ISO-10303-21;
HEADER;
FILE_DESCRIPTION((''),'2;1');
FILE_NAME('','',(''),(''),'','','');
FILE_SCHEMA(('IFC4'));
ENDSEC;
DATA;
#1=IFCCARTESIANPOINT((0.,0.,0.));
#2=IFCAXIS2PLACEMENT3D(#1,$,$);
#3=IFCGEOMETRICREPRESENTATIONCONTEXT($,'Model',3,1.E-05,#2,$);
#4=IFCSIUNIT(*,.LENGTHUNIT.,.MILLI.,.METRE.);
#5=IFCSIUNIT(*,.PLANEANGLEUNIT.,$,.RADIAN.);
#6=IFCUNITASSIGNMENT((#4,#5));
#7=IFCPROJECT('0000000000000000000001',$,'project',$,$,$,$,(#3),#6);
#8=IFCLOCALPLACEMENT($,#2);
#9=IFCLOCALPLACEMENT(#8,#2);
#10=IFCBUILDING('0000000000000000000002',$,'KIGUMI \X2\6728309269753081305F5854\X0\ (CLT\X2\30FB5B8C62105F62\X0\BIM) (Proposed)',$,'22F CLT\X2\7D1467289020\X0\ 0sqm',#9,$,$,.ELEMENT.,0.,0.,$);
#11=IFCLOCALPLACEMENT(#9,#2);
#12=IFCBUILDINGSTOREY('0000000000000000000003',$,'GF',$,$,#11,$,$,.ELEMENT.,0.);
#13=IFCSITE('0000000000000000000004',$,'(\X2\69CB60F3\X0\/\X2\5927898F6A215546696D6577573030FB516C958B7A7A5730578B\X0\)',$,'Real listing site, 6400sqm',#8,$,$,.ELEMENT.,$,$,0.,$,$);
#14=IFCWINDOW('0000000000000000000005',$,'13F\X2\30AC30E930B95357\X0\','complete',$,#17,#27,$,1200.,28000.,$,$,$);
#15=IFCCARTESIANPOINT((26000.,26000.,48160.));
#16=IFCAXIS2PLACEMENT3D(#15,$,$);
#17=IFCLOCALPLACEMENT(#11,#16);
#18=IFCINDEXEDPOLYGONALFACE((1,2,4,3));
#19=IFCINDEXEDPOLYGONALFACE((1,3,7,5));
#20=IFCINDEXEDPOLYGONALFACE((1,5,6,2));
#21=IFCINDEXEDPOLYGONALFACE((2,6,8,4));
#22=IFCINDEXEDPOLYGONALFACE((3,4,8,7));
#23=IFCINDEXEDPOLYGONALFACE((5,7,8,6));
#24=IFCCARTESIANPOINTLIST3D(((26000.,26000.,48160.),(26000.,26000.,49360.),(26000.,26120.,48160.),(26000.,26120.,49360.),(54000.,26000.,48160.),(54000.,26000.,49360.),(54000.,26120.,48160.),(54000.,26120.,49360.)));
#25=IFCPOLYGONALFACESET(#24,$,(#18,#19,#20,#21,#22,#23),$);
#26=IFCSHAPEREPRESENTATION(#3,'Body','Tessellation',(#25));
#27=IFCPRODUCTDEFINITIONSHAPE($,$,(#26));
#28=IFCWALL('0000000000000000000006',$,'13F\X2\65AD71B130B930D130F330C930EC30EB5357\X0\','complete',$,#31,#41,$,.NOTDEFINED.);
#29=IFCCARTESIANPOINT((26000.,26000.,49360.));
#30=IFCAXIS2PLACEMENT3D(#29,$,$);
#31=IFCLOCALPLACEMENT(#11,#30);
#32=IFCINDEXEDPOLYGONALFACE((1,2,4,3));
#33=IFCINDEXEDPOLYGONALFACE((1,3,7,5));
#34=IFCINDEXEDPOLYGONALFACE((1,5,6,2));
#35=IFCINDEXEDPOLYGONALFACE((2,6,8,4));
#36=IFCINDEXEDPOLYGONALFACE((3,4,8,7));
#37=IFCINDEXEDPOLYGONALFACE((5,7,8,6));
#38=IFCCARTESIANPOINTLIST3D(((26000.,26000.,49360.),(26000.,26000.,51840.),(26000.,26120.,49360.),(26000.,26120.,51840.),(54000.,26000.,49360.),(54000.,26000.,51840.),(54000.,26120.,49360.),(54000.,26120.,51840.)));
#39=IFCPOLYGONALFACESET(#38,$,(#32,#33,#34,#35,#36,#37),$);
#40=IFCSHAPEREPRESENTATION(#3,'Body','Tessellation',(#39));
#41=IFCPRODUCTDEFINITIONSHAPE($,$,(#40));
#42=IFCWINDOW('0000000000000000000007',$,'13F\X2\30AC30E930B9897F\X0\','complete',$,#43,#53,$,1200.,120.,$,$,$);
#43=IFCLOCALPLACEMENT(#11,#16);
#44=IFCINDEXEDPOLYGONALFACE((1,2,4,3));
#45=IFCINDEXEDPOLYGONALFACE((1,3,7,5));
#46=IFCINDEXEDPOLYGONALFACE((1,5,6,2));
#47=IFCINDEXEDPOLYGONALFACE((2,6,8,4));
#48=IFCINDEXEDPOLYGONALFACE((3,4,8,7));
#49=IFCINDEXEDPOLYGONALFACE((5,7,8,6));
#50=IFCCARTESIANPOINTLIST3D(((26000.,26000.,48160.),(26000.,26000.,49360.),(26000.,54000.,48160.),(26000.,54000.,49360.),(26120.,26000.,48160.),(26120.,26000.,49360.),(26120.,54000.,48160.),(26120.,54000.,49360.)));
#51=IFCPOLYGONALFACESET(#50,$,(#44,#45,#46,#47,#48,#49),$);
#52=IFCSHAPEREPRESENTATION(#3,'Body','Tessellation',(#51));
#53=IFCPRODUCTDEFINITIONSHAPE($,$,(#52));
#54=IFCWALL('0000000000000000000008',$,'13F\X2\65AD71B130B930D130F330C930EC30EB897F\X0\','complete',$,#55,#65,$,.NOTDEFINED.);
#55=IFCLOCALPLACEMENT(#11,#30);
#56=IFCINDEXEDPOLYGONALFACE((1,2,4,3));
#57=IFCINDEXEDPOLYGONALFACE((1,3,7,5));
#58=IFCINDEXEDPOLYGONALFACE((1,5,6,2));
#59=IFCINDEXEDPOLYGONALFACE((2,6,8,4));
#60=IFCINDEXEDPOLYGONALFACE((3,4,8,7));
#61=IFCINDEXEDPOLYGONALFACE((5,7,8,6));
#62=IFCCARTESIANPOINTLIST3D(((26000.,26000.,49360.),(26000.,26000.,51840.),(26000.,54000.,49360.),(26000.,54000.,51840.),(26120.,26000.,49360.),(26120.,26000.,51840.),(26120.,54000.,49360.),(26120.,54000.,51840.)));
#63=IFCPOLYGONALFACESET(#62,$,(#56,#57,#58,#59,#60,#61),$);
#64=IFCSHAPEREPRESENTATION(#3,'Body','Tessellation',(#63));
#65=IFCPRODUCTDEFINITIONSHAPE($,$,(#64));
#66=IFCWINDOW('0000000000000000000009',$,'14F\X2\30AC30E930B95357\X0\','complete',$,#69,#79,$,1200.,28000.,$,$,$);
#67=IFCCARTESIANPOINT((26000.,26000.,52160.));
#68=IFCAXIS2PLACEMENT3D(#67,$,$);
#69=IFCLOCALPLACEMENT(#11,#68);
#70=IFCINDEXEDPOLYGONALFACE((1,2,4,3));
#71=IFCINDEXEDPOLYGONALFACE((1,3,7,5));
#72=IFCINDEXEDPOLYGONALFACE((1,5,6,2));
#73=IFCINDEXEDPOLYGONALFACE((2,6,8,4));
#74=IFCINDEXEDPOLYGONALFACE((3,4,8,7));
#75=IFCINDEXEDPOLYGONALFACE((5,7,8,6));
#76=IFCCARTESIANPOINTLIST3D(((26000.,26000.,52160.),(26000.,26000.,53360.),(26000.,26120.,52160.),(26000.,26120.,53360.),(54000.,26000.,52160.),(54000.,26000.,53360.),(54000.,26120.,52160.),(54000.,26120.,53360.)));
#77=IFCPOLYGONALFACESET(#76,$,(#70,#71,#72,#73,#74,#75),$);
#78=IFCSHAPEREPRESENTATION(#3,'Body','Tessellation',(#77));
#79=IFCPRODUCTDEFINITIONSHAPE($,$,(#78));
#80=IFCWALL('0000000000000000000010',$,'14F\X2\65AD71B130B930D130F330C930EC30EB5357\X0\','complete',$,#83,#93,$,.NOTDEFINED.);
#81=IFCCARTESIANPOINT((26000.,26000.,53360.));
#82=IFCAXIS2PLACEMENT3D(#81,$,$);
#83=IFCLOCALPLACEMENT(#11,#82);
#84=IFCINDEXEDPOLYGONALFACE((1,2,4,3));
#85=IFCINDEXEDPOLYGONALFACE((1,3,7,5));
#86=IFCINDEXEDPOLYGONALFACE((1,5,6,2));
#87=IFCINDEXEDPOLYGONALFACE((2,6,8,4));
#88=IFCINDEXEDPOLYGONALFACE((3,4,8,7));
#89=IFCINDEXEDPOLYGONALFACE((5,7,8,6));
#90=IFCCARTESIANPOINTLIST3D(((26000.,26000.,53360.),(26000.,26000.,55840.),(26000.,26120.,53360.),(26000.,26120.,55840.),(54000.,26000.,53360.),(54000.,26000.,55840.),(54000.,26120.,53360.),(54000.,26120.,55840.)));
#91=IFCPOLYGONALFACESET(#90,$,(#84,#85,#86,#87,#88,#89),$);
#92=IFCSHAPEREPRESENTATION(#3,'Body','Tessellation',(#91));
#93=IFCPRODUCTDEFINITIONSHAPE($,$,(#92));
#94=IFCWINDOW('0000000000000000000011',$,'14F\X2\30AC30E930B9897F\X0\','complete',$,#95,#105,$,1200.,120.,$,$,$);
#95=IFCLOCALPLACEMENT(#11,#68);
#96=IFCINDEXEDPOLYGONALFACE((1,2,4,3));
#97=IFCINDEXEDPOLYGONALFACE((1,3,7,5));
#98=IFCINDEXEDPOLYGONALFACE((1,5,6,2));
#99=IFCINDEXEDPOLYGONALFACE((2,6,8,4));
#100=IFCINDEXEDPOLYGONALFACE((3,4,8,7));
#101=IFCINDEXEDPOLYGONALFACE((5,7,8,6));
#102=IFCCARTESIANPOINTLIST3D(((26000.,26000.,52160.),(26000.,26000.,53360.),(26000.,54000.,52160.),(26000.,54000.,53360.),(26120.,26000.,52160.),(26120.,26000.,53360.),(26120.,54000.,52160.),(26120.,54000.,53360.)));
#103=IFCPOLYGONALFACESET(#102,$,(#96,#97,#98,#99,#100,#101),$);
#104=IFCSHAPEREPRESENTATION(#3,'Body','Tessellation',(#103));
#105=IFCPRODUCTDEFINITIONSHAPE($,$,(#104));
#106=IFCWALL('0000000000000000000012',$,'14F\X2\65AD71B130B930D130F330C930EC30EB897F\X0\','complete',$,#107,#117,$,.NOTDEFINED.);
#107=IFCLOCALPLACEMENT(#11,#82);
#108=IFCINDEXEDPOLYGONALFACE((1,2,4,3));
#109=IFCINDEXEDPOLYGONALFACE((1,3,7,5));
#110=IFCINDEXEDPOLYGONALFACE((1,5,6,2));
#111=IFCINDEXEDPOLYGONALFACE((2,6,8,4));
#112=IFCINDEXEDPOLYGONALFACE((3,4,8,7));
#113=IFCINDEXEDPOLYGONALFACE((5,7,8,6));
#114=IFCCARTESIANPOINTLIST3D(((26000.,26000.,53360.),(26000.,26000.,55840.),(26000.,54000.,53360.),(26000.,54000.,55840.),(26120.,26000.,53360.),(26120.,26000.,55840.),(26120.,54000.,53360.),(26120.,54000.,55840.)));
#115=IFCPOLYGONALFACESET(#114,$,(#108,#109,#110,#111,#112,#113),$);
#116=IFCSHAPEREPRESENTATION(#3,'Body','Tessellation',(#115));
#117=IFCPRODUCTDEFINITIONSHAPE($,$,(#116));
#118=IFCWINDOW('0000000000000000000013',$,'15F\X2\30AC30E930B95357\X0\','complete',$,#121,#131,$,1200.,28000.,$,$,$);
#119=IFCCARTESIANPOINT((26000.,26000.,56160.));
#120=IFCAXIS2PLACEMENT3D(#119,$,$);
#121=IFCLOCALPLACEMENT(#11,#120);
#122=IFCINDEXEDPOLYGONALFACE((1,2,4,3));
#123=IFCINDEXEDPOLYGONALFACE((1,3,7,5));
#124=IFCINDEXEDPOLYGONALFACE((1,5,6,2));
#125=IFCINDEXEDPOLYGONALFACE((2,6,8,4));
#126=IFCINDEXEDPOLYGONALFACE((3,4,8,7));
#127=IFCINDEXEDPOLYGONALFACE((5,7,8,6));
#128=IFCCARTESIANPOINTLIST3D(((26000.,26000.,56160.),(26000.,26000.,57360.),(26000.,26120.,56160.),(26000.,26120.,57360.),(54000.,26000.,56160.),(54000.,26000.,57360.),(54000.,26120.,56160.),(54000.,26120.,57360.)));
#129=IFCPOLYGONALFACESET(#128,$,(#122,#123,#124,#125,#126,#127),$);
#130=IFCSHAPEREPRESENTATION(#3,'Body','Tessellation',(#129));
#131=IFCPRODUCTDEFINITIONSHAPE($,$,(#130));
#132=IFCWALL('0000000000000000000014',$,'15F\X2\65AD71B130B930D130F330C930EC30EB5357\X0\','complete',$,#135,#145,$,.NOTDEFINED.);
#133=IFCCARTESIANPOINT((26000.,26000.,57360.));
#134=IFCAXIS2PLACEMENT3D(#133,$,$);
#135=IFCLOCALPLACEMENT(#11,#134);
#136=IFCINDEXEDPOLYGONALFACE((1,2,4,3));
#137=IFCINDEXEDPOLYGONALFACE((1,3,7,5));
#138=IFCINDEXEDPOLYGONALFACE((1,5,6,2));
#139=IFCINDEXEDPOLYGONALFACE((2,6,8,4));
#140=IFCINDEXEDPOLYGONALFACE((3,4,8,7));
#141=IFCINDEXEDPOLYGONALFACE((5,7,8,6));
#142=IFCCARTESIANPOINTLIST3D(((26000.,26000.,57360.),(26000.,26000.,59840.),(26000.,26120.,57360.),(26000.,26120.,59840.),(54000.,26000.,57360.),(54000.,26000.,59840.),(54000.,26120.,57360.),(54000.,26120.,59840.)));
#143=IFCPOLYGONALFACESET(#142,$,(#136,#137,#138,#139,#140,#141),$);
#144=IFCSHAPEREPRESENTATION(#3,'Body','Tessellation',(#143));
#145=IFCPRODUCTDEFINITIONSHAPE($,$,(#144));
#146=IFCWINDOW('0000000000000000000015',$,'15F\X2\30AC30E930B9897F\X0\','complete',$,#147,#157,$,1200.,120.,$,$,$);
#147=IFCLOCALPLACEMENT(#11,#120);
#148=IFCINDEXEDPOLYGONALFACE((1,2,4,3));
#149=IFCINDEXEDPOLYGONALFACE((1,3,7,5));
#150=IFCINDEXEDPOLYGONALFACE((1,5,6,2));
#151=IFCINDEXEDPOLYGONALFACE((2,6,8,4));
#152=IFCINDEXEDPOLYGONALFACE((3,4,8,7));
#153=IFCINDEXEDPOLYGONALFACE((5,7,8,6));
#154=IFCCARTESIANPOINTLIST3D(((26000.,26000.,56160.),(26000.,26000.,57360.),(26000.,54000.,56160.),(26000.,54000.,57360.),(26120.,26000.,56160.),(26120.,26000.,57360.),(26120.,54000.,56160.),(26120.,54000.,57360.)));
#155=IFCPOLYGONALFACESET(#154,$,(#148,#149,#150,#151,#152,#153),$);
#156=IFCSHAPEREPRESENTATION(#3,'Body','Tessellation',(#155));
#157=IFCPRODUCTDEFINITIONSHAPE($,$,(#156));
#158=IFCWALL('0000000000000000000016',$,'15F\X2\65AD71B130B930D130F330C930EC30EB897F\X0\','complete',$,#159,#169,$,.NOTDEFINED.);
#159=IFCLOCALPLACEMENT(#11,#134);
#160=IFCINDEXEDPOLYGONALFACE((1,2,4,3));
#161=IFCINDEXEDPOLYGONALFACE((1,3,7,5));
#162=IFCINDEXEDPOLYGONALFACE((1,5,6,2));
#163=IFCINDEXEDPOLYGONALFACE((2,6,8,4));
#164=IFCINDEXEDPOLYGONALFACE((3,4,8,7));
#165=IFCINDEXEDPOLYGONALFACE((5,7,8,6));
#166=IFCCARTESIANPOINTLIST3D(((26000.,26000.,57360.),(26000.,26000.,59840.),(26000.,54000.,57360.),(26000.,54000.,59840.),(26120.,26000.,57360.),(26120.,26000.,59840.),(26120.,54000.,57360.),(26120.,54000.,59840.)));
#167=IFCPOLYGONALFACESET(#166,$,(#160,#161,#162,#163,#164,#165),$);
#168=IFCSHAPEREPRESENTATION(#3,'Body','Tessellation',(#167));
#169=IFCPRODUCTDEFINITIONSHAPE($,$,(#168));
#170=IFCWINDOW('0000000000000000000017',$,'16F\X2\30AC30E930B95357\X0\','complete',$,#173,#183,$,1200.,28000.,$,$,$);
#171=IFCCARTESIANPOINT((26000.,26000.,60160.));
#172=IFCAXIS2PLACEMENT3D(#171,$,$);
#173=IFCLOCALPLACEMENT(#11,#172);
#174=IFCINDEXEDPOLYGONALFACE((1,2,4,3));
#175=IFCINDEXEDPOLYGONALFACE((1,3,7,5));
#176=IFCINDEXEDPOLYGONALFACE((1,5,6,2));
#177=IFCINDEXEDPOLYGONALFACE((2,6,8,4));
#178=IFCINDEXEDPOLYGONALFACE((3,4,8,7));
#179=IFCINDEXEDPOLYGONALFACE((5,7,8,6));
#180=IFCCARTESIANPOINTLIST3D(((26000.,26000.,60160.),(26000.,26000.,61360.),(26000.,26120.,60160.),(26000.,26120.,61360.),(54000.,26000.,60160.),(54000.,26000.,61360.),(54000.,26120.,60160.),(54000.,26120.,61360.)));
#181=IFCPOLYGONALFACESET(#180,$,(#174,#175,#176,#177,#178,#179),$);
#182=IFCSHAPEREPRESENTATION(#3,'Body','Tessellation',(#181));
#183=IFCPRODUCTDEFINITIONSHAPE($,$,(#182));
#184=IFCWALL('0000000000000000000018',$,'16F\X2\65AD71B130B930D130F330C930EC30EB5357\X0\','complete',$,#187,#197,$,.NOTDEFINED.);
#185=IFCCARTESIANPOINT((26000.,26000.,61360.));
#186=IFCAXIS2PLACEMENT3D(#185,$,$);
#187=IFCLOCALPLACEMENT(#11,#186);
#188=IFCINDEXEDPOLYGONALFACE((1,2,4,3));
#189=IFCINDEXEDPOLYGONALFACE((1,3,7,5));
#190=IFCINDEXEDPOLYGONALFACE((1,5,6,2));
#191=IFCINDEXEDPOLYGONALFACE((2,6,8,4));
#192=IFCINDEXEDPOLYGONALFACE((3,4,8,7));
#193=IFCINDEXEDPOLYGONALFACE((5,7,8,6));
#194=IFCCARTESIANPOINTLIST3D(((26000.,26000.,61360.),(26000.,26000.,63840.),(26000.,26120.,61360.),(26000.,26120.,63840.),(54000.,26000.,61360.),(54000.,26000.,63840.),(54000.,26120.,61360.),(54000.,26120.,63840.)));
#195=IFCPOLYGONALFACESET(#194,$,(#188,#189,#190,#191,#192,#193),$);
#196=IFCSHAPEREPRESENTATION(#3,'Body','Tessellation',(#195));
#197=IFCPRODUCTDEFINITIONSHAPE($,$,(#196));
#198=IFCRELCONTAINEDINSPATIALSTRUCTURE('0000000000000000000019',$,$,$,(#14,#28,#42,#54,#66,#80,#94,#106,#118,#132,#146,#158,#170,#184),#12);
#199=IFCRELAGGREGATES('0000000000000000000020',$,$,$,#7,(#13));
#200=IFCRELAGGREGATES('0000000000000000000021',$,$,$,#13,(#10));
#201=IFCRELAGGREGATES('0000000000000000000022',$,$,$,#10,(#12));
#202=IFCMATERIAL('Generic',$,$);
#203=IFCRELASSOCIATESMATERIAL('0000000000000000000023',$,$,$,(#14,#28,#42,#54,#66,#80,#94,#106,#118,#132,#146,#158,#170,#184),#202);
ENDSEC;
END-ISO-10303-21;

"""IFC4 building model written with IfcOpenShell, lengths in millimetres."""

from ifc_helpers import new_model, si_unit, frame, frame_2d, origin, place, context, project, spatial, rectangle, extrude, material, element, save


model = new_model("IFC4")

# Units and contexts
model_context = context("Model", 3, precision=1e-05, world=origin())
ifc_project = project(units=[si_unit("LENGTHUNIT", "METRE", prefix="MILLI"), si_unit("PLANEANGLEUNIT", "RADIAN")], contexts=[model_context])

# Site, building, storey
site_placement = place(None, origin())
site = spatial("IfcSite", under=ifc_project, at=site_placement, Name="(構想/大規模商業敷地・公開空地型)", ObjectType="Real listing site, 6400sqm", CompositionType="ELEMENT", RefElevation=0.0)
building_placement = place(site_placement, origin())
building = spatial("IfcBuilding", under=site, at=building_placement, Name="KIGUMI 木を極めた塔 (CLT・完成形BIM) (Proposed)", ObjectType="22F CLT純木造 0sqm", CompositionType="ELEMENT", ElevationOfRefHeight=0.0, ElevationOfTerrain=0.0)
storey_placement = place(building_placement, origin())
storey = spatial("IfcBuildingStorey", under=building, at=storey_placement, Name="GF", CompositionType="ELEMENT", Elevation=0.0)

# Shared definitions
ifc_material = material(Name="Generic")

# Window
window_1_placement = place(storey_placement, frame((26000.0, 26000.0, 48160.0)))
element("IfcWindow", 1, at=window_1_placement, inside=storey, material=ifc_material, Name="13Fガラス南", Description="complete", OverallHeight=1200.0, OverallWidth=28000.0, context=model_context, shape_type="SweptSolid", body=[
    extrude(rectangle(XDim=28000.0, YDim=120.0, at=frame_2d((14000.0, 60.0))), frame((26000.0, 26000.0, 48160.0)), (0.0, 0.0, 1.0), 1200.0),
])

# Wall
wall_1_placement = place(storey_placement, frame((26000.0, 26000.0, 49360.0)))
element("IfcWall", 2, at=wall_1_placement, inside=storey, material=ifc_material, Name="13F断熱スパンドレル南", Description="complete", PredefinedType="NOTDEFINED", context=model_context, shape_type="SweptSolid", body=[
    extrude(rectangle(XDim=28000.0, YDim=120.0, at=frame_2d((14000.0, 60.0))), frame((26000.0, 26000.0, 49360.0)), (0.0, 0.0, 1.0), 2480.0),
])

# Window
window_2_placement = place(storey_placement, frame((26000.0, 26000.0, 48160.0)))
element("IfcWindow", 3, at=window_2_placement, inside=storey, material=ifc_material, Name="13Fガラス西", Description="complete", OverallHeight=1200.0, OverallWidth=120.0, context=model_context, shape_type="SweptSolid", body=[
    extrude(rectangle(XDim=120.0, YDim=28000.0, at=frame_2d((60.0, 14000.0))), frame((26000.0, 26000.0, 48160.0)), (0.0, 0.0, 1.0), 1200.0),
])

# Wall
wall_2_placement = place(storey_placement, frame((26000.0, 26000.0, 49360.0)))
element("IfcWall", 4, at=wall_2_placement, inside=storey, material=ifc_material, Name="13F断熱スパンドレル西", Description="complete", PredefinedType="NOTDEFINED", context=model_context, shape_type="SweptSolid", body=[
    extrude(rectangle(XDim=120.0, YDim=28000.0, at=frame_2d((60.0, 14000.0))), frame((26000.0, 26000.0, 49360.0)), (0.0, 0.0, 1.0), 2480.0),
])

# Window
window_3_placement = place(storey_placement, frame((26000.0, 26000.0, 52160.0)))
element("IfcWindow", 5, at=window_3_placement, inside=storey, material=ifc_material, Name="14Fガラス南", Description="complete", OverallHeight=1200.0, OverallWidth=28000.0, context=model_context, shape_type="SweptSolid", body=[
    extrude(rectangle(XDim=28000.0, YDim=120.0, at=frame_2d((14000.0, 60.0))), frame((26000.0, 26000.0, 52160.0)), (0.0, 0.0, 1.0), 1200.0),
])

# Wall
wall_3_placement = place(storey_placement, frame((26000.0, 26000.0, 53360.0)))
element("IfcWall", 6, at=wall_3_placement, inside=storey, material=ifc_material, Name="14F断熱スパンドレル南", Description="complete", PredefinedType="NOTDEFINED", context=model_context, shape_type="SweptSolid", body=[
    extrude(rectangle(XDim=28000.0, YDim=120.0, at=frame_2d((14000.0, 60.0))), frame((26000.0, 26000.0, 53360.0)), (0.0, 0.0, 1.0), 2480.0),
])

# Window
window_4_placement = place(storey_placement, frame((26000.0, 26000.0, 52160.0)))
element("IfcWindow", 7, at=window_4_placement, inside=storey, material=ifc_material, Name="14Fガラス西", Description="complete", OverallHeight=1200.0, OverallWidth=120.0, context=model_context, shape_type="SweptSolid", body=[
    extrude(rectangle(XDim=120.0, YDim=28000.0, at=frame_2d((60.0, 14000.0))), frame((26000.0, 26000.0, 52160.0)), (0.0, 0.0, 1.0), 1200.0),
])

# Wall
wall_4_placement = place(storey_placement, frame((26000.0, 26000.0, 53360.0)))
element("IfcWall", 8, at=wall_4_placement, inside=storey, material=ifc_material, Name="14F断熱スパンドレル西", Description="complete", PredefinedType="NOTDEFINED", context=model_context, shape_type="SweptSolid", body=[
    extrude(rectangle(XDim=120.0, YDim=28000.0, at=frame_2d((60.0, 14000.0))), frame((26000.0, 26000.0, 53360.0)), (0.0, 0.0, 1.0), 2480.0),
])

# Window
window_5_placement = place(storey_placement, frame((26000.0, 26000.0, 56160.0)))
element("IfcWindow", 9, at=window_5_placement, inside=storey, material=ifc_material, Name="15Fガラス南", Description="complete", OverallHeight=1200.0, OverallWidth=28000.0, context=model_context, shape_type="SweptSolid", body=[
    extrude(rectangle(XDim=28000.0, YDim=120.0, at=frame_2d((14000.0, 60.0))), frame((26000.0, 26000.0, 56160.0)), (0.0, 0.0, 1.0), 1200.0),
])

# Wall
wall_5_placement = place(storey_placement, frame((26000.0, 26000.0, 57360.0)))
element("IfcWall", 10, at=wall_5_placement, inside=storey, material=ifc_material, Name="15F断熱スパンドレル南", Description="complete", PredefinedType="NOTDEFINED", context=model_context, shape_type="SweptSolid", body=[
    extrude(rectangle(XDim=28000.0, YDim=120.0, at=frame_2d((14000.0, 60.0))), frame((26000.0, 26000.0, 57360.0)), (0.0, 0.0, 1.0), 2480.0),
])

# Window
window_6_placement = place(storey_placement, frame((26000.0, 26000.0, 56160.0)))
element("IfcWindow", 11, at=window_6_placement, inside=storey, material=ifc_material, Name="15Fガラス西", Description="complete", OverallHeight=1200.0, OverallWidth=120.0, context=model_context, shape_type="SweptSolid", body=[
    extrude(rectangle(XDim=120.0, YDim=28000.0, at=frame_2d((60.0, 14000.0))), frame((26000.0, 26000.0, 56160.0)), (0.0, 0.0, 1.0), 1200.0),
])

# Wall
wall_6_placement = place(storey_placement, frame((26000.0, 26000.0, 57360.0)))
element("IfcWall", 12, at=wall_6_placement, inside=storey, material=ifc_material, Name="15F断熱スパンドレル西", Description="complete", PredefinedType="NOTDEFINED", context=model_context, shape_type="SweptSolid", body=[
    extrude(rectangle(XDim=120.0, YDim=28000.0, at=frame_2d((60.0, 14000.0))), frame((26000.0, 26000.0, 57360.0)), (0.0, 0.0, 1.0), 2480.0),
])

# Window
window_7_placement = place(storey_placement, frame((26000.0, 26000.0, 60160.0)))
element("IfcWindow", 13, at=window_7_placement, inside=storey, material=ifc_material, Name="16Fガラス南", Description="complete", OverallHeight=1200.0, OverallWidth=28000.0, context=model_context, shape_type="SweptSolid", body=[
    extrude(rectangle(XDim=28000.0, YDim=120.0, at=frame_2d((14000.0, 60.0))), frame((26000.0, 26000.0, 60160.0)), (0.0, 0.0, 1.0), 1200.0),
])

# Wall
wall_7_placement = place(storey_placement, frame((26000.0, 26000.0, 61360.0)))
element("IfcWall", 14, at=wall_7_placement, inside=storey, material=ifc_material, Name="16F断熱スパンドレル南", Description="complete", PredefinedType="NOTDEFINED", context=model_context, shape_type="SweptSolid", body=[
    extrude(rectangle(XDim=28000.0, YDim=120.0, at=frame_2d((14000.0, 60.0))), frame((26000.0, 26000.0, 61360.0)), (0.0, 0.0, 1.0), 2480.0),
])

save(model, "model.ifc")
